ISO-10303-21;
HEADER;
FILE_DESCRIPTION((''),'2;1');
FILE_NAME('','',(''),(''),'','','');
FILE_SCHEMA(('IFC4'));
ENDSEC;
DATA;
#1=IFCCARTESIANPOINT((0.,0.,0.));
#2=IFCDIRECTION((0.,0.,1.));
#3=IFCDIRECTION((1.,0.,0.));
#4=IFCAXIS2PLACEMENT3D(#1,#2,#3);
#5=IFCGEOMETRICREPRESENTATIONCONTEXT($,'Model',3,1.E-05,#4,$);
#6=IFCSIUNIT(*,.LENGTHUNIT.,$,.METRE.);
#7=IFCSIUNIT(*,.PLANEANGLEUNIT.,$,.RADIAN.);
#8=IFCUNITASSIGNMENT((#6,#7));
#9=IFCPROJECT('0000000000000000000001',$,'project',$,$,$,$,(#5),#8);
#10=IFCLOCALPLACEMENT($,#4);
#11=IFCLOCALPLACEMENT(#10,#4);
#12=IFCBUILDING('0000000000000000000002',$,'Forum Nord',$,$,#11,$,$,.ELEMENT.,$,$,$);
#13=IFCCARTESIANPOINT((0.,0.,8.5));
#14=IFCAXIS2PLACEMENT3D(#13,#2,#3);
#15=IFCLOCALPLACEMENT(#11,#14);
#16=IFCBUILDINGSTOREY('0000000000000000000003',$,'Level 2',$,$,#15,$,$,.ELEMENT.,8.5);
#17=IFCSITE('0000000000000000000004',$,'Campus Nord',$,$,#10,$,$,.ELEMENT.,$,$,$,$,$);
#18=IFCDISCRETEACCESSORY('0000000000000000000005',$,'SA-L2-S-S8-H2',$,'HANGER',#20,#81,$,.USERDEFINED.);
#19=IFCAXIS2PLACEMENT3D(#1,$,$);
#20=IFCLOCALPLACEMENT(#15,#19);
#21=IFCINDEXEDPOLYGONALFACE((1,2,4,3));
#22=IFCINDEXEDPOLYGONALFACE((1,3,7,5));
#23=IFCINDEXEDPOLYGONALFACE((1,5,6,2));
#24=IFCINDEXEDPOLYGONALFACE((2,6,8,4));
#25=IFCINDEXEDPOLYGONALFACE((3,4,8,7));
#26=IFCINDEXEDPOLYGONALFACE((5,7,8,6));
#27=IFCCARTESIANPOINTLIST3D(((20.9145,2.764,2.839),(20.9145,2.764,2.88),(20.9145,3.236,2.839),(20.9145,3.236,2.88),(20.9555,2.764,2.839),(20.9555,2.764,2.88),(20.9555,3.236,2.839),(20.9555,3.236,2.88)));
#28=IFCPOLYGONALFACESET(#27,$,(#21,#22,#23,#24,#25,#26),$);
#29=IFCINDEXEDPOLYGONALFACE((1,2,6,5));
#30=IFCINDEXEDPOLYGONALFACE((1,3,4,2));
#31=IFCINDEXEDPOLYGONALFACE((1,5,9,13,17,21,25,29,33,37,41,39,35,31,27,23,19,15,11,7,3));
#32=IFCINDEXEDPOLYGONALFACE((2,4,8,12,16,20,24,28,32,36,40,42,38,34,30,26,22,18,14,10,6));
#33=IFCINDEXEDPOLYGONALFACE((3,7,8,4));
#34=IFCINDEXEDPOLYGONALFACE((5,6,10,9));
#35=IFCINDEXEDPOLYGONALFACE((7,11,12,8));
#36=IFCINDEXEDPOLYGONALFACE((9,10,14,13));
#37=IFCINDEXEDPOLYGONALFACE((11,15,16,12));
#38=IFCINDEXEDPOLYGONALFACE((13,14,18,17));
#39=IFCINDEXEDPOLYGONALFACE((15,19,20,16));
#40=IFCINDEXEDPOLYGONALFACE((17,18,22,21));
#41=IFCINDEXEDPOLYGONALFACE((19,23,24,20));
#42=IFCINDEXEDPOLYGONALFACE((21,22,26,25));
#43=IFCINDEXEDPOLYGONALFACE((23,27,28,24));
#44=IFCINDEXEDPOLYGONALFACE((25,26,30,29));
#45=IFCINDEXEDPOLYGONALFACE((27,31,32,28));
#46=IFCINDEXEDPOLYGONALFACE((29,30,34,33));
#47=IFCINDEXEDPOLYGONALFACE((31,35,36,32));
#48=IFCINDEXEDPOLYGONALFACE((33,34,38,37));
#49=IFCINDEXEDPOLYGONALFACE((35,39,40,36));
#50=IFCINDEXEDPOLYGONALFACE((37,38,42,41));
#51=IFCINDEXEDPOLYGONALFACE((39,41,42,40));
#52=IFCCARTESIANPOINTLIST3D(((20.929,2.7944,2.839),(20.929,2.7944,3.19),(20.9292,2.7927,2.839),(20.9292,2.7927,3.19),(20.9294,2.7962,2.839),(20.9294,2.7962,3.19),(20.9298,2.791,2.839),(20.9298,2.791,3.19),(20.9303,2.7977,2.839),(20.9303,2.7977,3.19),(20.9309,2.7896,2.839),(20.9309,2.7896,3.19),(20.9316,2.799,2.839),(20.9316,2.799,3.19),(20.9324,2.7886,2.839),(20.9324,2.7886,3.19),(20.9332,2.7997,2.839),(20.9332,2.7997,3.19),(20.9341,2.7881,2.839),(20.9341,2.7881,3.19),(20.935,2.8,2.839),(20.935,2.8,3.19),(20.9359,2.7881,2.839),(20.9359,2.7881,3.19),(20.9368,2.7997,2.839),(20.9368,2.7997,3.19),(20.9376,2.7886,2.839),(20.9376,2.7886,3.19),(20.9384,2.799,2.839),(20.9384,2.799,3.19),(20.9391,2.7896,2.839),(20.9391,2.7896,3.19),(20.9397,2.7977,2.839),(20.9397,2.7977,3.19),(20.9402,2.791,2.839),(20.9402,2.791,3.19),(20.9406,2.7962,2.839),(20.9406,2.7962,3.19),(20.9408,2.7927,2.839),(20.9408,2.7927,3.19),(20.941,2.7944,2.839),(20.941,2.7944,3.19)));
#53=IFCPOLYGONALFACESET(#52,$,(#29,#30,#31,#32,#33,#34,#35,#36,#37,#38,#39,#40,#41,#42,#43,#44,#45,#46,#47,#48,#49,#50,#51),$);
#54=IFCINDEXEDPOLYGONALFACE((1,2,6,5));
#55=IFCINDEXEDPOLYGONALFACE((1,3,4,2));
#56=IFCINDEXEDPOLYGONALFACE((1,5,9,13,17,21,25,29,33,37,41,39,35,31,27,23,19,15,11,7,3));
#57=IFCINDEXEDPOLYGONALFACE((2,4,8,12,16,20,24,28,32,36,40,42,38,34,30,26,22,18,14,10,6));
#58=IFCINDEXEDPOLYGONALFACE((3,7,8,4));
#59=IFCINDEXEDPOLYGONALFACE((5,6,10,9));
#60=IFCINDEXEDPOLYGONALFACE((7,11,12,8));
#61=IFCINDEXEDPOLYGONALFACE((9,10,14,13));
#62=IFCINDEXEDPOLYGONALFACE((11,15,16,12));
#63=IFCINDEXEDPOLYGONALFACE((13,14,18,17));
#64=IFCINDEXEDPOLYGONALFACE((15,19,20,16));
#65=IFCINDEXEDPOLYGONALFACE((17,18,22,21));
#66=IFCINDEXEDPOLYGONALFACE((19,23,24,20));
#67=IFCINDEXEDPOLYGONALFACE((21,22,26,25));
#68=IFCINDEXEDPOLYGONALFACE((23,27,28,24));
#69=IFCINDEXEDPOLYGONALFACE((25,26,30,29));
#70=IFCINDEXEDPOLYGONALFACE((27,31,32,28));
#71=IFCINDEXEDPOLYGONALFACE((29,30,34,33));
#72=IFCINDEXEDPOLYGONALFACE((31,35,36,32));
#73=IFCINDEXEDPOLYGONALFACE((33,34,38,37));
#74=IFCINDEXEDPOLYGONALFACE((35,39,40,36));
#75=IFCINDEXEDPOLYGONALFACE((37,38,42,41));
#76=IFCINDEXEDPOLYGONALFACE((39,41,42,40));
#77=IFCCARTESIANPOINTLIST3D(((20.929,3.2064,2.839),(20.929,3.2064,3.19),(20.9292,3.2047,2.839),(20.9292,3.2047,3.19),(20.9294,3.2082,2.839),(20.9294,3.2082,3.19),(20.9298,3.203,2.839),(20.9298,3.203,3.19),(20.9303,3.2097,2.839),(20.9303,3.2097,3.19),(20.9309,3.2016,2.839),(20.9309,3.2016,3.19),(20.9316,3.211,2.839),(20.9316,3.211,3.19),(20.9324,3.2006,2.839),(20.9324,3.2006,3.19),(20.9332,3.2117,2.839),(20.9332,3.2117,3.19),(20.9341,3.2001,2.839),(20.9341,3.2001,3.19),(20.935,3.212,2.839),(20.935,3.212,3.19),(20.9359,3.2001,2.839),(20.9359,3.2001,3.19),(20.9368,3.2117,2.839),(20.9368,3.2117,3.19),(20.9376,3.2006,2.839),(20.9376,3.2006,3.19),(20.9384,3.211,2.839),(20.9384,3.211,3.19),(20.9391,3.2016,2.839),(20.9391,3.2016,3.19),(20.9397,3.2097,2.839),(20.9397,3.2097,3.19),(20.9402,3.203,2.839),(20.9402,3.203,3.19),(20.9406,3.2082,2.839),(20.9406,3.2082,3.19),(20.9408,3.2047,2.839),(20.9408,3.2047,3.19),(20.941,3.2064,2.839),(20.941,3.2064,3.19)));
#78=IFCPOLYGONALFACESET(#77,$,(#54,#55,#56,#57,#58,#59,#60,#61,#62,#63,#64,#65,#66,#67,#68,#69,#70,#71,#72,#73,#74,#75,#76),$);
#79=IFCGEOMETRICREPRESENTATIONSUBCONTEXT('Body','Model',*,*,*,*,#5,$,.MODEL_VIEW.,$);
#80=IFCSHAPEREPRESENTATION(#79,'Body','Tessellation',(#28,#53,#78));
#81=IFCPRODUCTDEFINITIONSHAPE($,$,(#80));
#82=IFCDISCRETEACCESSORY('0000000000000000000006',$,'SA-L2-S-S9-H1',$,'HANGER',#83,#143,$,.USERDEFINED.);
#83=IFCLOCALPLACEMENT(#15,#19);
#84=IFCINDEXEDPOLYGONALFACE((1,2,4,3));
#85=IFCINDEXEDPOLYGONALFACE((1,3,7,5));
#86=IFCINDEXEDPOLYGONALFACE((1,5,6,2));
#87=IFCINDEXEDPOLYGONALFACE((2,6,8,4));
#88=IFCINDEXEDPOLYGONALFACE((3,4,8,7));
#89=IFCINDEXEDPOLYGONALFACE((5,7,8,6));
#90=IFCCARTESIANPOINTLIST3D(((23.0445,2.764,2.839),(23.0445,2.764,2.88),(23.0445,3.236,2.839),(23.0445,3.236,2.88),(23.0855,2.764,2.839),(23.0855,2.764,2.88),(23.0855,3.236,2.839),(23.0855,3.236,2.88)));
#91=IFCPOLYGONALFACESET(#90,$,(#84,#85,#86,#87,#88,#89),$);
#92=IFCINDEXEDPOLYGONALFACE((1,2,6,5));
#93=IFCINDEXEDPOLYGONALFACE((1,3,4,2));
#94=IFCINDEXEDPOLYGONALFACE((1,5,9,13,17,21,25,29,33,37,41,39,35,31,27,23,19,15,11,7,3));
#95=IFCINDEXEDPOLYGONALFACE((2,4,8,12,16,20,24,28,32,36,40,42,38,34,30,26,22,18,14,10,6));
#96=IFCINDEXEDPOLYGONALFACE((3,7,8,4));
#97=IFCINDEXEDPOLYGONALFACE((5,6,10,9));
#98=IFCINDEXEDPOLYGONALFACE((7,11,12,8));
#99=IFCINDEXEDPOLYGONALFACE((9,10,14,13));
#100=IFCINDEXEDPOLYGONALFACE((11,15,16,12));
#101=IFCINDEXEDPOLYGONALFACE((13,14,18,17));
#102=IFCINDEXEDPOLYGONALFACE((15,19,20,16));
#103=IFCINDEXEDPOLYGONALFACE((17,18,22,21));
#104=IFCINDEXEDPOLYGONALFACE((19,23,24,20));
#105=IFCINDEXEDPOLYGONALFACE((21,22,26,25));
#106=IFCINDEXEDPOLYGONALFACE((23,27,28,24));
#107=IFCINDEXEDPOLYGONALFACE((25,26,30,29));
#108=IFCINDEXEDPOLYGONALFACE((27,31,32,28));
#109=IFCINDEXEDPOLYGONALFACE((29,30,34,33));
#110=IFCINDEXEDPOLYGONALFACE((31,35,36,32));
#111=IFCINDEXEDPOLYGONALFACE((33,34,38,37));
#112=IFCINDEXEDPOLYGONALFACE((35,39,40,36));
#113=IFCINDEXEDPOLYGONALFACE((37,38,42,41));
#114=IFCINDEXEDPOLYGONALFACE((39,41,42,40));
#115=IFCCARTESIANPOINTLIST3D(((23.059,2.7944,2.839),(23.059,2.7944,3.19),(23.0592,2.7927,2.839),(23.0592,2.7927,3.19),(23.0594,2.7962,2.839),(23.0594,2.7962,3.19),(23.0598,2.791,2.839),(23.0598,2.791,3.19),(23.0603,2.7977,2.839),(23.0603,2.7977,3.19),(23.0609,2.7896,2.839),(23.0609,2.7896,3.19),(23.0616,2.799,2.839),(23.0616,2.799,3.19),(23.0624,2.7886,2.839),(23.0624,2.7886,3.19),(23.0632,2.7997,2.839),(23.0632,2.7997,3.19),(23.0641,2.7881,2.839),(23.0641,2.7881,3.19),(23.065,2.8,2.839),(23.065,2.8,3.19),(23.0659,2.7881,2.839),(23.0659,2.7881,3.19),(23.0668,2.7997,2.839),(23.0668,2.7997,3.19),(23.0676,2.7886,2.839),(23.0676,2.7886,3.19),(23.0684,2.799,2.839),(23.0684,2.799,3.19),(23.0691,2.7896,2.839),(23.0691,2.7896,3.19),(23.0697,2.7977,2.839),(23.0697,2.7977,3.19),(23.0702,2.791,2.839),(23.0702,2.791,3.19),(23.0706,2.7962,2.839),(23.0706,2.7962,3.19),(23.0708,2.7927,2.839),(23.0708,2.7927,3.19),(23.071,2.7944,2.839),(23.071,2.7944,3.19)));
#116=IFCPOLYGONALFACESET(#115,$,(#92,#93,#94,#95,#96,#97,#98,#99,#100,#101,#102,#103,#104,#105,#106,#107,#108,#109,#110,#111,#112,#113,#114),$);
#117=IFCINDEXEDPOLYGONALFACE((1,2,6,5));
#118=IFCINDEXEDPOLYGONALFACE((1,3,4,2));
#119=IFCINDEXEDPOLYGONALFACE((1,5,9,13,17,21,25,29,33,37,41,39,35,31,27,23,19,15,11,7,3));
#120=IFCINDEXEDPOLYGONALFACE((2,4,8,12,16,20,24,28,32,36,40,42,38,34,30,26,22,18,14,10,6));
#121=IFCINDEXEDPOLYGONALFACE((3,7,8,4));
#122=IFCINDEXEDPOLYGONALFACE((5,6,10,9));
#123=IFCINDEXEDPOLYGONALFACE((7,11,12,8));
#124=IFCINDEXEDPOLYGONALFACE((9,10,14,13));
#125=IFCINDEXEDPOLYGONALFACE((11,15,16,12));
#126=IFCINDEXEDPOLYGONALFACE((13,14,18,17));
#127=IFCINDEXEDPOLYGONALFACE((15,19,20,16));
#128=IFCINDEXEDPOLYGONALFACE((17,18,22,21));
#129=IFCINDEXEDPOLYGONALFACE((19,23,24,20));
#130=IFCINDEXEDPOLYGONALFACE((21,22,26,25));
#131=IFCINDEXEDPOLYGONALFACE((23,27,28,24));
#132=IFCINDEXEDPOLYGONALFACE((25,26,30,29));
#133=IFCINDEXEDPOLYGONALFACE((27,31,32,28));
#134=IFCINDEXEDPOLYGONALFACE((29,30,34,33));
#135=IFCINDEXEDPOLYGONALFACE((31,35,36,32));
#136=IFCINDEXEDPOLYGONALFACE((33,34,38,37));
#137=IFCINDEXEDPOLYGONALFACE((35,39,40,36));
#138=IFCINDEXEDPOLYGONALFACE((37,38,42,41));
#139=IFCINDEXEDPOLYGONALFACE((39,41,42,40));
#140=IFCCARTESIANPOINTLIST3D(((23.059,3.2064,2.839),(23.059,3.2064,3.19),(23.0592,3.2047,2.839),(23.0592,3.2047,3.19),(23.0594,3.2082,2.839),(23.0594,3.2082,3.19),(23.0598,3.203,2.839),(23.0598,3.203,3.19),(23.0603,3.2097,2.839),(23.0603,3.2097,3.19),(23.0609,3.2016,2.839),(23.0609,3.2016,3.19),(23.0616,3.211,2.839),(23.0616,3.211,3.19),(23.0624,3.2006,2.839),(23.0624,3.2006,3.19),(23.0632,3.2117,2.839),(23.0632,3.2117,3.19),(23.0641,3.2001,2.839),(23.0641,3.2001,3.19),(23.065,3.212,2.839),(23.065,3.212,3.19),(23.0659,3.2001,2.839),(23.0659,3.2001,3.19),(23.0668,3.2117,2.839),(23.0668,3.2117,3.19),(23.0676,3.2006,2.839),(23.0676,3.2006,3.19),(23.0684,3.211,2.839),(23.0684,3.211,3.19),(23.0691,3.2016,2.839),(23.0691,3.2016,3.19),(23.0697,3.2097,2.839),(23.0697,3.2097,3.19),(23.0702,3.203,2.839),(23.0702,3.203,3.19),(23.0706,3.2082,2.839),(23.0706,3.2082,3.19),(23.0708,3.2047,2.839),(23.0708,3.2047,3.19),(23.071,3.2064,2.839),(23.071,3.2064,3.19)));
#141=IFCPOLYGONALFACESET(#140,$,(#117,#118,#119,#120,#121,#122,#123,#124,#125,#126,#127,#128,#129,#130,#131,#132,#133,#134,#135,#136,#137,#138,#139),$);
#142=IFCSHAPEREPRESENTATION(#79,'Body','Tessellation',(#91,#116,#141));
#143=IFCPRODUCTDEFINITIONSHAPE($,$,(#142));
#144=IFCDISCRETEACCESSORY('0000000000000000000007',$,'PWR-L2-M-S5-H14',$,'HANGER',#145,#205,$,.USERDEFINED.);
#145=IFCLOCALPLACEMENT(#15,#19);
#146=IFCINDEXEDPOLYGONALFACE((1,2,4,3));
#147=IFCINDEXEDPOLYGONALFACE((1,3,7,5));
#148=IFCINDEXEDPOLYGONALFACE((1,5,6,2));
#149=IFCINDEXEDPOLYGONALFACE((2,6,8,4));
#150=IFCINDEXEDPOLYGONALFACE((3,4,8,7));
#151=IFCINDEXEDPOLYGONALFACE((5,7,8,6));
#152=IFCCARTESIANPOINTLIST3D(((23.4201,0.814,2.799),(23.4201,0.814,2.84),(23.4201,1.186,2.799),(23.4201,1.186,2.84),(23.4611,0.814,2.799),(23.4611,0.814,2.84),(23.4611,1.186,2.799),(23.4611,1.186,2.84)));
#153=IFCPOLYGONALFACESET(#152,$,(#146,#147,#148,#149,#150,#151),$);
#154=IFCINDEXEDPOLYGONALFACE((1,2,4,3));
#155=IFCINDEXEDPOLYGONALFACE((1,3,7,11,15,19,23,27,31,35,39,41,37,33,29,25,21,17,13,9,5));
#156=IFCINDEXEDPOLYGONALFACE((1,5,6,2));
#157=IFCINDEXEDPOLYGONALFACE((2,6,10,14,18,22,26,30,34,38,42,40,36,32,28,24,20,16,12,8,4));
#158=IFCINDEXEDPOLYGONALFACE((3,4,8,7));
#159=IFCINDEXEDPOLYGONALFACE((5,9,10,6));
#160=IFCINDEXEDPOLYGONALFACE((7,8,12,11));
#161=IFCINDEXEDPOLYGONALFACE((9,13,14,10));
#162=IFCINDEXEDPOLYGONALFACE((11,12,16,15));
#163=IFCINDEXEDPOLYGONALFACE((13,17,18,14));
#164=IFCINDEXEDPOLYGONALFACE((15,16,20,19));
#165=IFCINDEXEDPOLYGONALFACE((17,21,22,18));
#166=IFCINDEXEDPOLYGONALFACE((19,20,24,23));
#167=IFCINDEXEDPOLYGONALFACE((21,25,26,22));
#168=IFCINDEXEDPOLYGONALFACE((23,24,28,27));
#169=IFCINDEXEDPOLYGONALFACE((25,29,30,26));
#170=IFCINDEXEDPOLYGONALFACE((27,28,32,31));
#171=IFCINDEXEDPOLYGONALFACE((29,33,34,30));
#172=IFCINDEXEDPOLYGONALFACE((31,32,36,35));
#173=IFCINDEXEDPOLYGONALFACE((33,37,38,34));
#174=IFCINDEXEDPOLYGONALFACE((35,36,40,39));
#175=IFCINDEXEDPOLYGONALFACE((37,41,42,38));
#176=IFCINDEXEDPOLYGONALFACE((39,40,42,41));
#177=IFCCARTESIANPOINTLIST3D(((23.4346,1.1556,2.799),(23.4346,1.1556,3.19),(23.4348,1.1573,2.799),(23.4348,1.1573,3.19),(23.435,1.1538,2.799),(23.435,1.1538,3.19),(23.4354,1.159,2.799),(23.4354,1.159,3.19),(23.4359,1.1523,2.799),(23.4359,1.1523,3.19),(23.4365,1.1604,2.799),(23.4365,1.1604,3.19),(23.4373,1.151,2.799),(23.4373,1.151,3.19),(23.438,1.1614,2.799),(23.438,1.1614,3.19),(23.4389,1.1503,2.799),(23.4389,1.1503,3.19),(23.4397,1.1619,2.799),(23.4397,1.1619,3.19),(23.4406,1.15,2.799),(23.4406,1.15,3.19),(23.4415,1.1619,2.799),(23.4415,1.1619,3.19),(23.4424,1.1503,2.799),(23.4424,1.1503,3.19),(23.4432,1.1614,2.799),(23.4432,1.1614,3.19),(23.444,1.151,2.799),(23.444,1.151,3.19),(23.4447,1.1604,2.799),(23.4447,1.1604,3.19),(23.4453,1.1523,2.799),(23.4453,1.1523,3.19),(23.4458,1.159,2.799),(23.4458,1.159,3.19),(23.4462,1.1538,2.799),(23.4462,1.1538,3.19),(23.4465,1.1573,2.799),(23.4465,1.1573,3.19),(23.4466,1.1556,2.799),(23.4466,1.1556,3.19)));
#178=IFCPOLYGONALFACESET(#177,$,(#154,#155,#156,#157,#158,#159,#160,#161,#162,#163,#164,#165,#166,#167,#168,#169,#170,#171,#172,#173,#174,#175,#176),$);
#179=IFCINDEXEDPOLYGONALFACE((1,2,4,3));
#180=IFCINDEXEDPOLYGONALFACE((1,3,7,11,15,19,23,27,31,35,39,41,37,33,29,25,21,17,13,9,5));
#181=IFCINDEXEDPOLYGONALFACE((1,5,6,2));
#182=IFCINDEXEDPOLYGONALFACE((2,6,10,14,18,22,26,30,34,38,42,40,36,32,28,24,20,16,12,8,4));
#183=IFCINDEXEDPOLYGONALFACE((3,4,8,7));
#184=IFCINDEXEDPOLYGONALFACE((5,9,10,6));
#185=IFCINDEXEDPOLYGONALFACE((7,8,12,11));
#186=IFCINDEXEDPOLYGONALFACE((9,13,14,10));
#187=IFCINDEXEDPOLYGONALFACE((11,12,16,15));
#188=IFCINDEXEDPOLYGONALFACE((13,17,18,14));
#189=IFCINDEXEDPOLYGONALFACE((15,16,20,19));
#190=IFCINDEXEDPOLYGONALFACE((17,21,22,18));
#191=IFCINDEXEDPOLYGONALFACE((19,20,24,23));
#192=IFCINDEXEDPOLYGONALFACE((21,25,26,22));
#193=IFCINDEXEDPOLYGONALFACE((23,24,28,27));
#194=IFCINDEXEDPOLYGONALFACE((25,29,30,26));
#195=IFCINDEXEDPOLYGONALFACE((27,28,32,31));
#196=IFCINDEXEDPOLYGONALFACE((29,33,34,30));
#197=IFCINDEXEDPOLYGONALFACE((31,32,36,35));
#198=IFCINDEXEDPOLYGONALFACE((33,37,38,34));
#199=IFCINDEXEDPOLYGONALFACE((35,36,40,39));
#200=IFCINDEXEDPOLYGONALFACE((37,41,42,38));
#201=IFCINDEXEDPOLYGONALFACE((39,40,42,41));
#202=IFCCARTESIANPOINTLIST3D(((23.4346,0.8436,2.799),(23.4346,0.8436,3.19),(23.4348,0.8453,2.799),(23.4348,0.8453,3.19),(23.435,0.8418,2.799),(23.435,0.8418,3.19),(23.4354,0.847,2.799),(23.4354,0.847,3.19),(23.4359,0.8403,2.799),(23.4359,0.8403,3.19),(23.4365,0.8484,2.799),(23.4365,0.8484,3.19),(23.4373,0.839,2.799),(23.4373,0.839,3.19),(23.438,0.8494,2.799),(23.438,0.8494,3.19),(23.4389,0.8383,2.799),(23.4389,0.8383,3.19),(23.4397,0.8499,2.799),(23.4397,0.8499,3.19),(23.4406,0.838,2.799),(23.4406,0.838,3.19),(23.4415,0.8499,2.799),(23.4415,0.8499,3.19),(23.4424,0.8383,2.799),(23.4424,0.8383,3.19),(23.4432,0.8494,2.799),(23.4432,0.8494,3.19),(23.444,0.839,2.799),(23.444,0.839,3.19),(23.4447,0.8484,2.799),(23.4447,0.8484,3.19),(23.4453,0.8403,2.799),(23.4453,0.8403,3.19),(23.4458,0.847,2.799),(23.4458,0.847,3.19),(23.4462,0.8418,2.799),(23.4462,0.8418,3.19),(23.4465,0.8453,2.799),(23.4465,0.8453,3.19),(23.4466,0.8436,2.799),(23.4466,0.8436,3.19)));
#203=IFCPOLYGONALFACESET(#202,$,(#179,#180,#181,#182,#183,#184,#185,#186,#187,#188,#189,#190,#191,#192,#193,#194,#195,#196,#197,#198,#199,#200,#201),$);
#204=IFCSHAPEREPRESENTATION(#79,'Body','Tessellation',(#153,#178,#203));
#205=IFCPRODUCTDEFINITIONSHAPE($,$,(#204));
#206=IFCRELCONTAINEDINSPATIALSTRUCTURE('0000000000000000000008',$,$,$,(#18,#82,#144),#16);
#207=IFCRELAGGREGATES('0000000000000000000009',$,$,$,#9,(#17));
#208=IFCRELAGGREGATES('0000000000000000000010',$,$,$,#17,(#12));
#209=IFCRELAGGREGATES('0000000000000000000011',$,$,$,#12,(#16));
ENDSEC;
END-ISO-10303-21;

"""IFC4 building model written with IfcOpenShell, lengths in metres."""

from ifc_helpers import new_model, si_unit, frame, frame_2d, origin_with_axes, origin_2d_with_axis, place, context, subcontext, project, spatial, rectangle, circle, extrude, element, save


model = new_model("IFC4")

# Units and contexts
model_context = context("Model", 3, precision=1e-05, world=origin_with_axes())
body_context = subcontext(model_context, "Body", "Model", "MODEL_VIEW")
ifc_project = project(units=[si_unit("LENGTHUNIT", "METRE"), si_unit("PLANEANGLEUNIT", "RADIAN")], contexts=[model_context])

# Site, building, storey
site_placement = place(None, origin_with_axes())
site = spatial("IfcSite", under=ifc_project, at=site_placement, Name="Campus Nord", CompositionType="ELEMENT")
building_placement = place(site_placement, origin_with_axes())
building = spatial("IfcBuilding", under=site, at=building_placement, Name="Forum Nord", CompositionType="ELEMENT")
storey_placement = place(building_placement, frame((0.0, 0.0, 8.5), z_axis=(0.0, 0.0, 1.0), x_axis=(1.0, 0.0, 0.0)))
storey = spatial("IfcBuildingStorey", under=building, at=storey_placement, Name="Level 2", CompositionType="ELEMENT", Elevation=8.5)

# Discrete accessories
for number, where, z_axis, x_axis, name in (
    (1, (20.935, 3.0, 2.88), (0.0, 0.0, 1.0), (0.0, 1.0, 0.0), "SA-L2-S-S8-H2"),
    (2, (23.065, 3.0, 2.88), (0.0, 0.0, 1.0), (0.0, 1.0, 0.0), "SA-L2-S-S9-H1"),
):
    element("IfcDiscreteAccessory", number, at=place(storey_placement, frame(where, z_axis=z_axis, x_axis=x_axis)), inside=storey, Name=name, ObjectType="HANGER", PredefinedType="USERDEFINED", context=body_context, shape_type="SweptSolid", body=[
        extrude(rectangle(XDim=0.472, YDim=0.041, at=origin_2d_with_axis()), frame((0.0, 0.0, -0.041), z_axis=(0.0, 0.0, 1.0), x_axis=(1.0, 0.0, 0.0)), (0.0, 0.0, 1.0), 0.041),
        extrude(circle(Radius=0.006, at=frame_2d((-0.206, 0.0), x_axis=(1.0, 0.0))), frame((0.0, 0.0, -0.041), z_axis=(0.0, 0.0, 1.0), x_axis=(1.0, 0.0, 0.0)), (0.0, 0.0, 1.0), 0.351),
        extrude(circle(Radius=0.006, at=frame_2d((0.206, 0.0), x_axis=(1.0, 0.0))), frame((0.0, 0.0, -0.041), z_axis=(0.0, 0.0, 1.0), x_axis=(1.0, 0.0, 0.0)), (0.0, 0.0, 1.0), 0.351),
    ])
for number, where, z_axis, x_axis, name in (
    (3, (23.4406, 1.0, 2.84), (0.0, 0.0, 1.0), (0.0, -1.0, 0.0), "PWR-L2-M-S5-H14"),
):
    element("IfcDiscreteAccessory", number, at=place(storey_placement, frame(where, z_axis=z_axis, x_axis=x_axis)), inside=storey, Name=name, ObjectType="HANGER", PredefinedType="USERDEFINED", context=body_context, shape_type="SweptSolid", body=[
        extrude(rectangle(XDim=0.372, YDim=0.041, at=origin_2d_with_axis()), frame((0.0, 0.0, -0.041), z_axis=(0.0, 0.0, 1.0), x_axis=(1.0, 0.0, 0.0)), (0.0, 0.0, 1.0), 0.041),
        extrude(circle(Radius=0.006, at=frame_2d((-0.156, 0.0), x_axis=(1.0, 0.0))), frame((0.0, 0.0, -0.041), z_axis=(0.0, 0.0, 1.0), x_axis=(1.0, 0.0, 0.0)), (0.0, 0.0, 1.0), 0.391),
        extrude(circle(Radius=0.006, at=frame_2d((0.156, 0.0), x_axis=(1.0, 0.0))), frame((0.0, 0.0, -0.041), z_axis=(0.0, 0.0, 1.0), x_axis=(1.0, 0.0, 0.0)), (0.0, 0.0, 1.0), 0.391),
    ])

save(model, "model.ifc")
